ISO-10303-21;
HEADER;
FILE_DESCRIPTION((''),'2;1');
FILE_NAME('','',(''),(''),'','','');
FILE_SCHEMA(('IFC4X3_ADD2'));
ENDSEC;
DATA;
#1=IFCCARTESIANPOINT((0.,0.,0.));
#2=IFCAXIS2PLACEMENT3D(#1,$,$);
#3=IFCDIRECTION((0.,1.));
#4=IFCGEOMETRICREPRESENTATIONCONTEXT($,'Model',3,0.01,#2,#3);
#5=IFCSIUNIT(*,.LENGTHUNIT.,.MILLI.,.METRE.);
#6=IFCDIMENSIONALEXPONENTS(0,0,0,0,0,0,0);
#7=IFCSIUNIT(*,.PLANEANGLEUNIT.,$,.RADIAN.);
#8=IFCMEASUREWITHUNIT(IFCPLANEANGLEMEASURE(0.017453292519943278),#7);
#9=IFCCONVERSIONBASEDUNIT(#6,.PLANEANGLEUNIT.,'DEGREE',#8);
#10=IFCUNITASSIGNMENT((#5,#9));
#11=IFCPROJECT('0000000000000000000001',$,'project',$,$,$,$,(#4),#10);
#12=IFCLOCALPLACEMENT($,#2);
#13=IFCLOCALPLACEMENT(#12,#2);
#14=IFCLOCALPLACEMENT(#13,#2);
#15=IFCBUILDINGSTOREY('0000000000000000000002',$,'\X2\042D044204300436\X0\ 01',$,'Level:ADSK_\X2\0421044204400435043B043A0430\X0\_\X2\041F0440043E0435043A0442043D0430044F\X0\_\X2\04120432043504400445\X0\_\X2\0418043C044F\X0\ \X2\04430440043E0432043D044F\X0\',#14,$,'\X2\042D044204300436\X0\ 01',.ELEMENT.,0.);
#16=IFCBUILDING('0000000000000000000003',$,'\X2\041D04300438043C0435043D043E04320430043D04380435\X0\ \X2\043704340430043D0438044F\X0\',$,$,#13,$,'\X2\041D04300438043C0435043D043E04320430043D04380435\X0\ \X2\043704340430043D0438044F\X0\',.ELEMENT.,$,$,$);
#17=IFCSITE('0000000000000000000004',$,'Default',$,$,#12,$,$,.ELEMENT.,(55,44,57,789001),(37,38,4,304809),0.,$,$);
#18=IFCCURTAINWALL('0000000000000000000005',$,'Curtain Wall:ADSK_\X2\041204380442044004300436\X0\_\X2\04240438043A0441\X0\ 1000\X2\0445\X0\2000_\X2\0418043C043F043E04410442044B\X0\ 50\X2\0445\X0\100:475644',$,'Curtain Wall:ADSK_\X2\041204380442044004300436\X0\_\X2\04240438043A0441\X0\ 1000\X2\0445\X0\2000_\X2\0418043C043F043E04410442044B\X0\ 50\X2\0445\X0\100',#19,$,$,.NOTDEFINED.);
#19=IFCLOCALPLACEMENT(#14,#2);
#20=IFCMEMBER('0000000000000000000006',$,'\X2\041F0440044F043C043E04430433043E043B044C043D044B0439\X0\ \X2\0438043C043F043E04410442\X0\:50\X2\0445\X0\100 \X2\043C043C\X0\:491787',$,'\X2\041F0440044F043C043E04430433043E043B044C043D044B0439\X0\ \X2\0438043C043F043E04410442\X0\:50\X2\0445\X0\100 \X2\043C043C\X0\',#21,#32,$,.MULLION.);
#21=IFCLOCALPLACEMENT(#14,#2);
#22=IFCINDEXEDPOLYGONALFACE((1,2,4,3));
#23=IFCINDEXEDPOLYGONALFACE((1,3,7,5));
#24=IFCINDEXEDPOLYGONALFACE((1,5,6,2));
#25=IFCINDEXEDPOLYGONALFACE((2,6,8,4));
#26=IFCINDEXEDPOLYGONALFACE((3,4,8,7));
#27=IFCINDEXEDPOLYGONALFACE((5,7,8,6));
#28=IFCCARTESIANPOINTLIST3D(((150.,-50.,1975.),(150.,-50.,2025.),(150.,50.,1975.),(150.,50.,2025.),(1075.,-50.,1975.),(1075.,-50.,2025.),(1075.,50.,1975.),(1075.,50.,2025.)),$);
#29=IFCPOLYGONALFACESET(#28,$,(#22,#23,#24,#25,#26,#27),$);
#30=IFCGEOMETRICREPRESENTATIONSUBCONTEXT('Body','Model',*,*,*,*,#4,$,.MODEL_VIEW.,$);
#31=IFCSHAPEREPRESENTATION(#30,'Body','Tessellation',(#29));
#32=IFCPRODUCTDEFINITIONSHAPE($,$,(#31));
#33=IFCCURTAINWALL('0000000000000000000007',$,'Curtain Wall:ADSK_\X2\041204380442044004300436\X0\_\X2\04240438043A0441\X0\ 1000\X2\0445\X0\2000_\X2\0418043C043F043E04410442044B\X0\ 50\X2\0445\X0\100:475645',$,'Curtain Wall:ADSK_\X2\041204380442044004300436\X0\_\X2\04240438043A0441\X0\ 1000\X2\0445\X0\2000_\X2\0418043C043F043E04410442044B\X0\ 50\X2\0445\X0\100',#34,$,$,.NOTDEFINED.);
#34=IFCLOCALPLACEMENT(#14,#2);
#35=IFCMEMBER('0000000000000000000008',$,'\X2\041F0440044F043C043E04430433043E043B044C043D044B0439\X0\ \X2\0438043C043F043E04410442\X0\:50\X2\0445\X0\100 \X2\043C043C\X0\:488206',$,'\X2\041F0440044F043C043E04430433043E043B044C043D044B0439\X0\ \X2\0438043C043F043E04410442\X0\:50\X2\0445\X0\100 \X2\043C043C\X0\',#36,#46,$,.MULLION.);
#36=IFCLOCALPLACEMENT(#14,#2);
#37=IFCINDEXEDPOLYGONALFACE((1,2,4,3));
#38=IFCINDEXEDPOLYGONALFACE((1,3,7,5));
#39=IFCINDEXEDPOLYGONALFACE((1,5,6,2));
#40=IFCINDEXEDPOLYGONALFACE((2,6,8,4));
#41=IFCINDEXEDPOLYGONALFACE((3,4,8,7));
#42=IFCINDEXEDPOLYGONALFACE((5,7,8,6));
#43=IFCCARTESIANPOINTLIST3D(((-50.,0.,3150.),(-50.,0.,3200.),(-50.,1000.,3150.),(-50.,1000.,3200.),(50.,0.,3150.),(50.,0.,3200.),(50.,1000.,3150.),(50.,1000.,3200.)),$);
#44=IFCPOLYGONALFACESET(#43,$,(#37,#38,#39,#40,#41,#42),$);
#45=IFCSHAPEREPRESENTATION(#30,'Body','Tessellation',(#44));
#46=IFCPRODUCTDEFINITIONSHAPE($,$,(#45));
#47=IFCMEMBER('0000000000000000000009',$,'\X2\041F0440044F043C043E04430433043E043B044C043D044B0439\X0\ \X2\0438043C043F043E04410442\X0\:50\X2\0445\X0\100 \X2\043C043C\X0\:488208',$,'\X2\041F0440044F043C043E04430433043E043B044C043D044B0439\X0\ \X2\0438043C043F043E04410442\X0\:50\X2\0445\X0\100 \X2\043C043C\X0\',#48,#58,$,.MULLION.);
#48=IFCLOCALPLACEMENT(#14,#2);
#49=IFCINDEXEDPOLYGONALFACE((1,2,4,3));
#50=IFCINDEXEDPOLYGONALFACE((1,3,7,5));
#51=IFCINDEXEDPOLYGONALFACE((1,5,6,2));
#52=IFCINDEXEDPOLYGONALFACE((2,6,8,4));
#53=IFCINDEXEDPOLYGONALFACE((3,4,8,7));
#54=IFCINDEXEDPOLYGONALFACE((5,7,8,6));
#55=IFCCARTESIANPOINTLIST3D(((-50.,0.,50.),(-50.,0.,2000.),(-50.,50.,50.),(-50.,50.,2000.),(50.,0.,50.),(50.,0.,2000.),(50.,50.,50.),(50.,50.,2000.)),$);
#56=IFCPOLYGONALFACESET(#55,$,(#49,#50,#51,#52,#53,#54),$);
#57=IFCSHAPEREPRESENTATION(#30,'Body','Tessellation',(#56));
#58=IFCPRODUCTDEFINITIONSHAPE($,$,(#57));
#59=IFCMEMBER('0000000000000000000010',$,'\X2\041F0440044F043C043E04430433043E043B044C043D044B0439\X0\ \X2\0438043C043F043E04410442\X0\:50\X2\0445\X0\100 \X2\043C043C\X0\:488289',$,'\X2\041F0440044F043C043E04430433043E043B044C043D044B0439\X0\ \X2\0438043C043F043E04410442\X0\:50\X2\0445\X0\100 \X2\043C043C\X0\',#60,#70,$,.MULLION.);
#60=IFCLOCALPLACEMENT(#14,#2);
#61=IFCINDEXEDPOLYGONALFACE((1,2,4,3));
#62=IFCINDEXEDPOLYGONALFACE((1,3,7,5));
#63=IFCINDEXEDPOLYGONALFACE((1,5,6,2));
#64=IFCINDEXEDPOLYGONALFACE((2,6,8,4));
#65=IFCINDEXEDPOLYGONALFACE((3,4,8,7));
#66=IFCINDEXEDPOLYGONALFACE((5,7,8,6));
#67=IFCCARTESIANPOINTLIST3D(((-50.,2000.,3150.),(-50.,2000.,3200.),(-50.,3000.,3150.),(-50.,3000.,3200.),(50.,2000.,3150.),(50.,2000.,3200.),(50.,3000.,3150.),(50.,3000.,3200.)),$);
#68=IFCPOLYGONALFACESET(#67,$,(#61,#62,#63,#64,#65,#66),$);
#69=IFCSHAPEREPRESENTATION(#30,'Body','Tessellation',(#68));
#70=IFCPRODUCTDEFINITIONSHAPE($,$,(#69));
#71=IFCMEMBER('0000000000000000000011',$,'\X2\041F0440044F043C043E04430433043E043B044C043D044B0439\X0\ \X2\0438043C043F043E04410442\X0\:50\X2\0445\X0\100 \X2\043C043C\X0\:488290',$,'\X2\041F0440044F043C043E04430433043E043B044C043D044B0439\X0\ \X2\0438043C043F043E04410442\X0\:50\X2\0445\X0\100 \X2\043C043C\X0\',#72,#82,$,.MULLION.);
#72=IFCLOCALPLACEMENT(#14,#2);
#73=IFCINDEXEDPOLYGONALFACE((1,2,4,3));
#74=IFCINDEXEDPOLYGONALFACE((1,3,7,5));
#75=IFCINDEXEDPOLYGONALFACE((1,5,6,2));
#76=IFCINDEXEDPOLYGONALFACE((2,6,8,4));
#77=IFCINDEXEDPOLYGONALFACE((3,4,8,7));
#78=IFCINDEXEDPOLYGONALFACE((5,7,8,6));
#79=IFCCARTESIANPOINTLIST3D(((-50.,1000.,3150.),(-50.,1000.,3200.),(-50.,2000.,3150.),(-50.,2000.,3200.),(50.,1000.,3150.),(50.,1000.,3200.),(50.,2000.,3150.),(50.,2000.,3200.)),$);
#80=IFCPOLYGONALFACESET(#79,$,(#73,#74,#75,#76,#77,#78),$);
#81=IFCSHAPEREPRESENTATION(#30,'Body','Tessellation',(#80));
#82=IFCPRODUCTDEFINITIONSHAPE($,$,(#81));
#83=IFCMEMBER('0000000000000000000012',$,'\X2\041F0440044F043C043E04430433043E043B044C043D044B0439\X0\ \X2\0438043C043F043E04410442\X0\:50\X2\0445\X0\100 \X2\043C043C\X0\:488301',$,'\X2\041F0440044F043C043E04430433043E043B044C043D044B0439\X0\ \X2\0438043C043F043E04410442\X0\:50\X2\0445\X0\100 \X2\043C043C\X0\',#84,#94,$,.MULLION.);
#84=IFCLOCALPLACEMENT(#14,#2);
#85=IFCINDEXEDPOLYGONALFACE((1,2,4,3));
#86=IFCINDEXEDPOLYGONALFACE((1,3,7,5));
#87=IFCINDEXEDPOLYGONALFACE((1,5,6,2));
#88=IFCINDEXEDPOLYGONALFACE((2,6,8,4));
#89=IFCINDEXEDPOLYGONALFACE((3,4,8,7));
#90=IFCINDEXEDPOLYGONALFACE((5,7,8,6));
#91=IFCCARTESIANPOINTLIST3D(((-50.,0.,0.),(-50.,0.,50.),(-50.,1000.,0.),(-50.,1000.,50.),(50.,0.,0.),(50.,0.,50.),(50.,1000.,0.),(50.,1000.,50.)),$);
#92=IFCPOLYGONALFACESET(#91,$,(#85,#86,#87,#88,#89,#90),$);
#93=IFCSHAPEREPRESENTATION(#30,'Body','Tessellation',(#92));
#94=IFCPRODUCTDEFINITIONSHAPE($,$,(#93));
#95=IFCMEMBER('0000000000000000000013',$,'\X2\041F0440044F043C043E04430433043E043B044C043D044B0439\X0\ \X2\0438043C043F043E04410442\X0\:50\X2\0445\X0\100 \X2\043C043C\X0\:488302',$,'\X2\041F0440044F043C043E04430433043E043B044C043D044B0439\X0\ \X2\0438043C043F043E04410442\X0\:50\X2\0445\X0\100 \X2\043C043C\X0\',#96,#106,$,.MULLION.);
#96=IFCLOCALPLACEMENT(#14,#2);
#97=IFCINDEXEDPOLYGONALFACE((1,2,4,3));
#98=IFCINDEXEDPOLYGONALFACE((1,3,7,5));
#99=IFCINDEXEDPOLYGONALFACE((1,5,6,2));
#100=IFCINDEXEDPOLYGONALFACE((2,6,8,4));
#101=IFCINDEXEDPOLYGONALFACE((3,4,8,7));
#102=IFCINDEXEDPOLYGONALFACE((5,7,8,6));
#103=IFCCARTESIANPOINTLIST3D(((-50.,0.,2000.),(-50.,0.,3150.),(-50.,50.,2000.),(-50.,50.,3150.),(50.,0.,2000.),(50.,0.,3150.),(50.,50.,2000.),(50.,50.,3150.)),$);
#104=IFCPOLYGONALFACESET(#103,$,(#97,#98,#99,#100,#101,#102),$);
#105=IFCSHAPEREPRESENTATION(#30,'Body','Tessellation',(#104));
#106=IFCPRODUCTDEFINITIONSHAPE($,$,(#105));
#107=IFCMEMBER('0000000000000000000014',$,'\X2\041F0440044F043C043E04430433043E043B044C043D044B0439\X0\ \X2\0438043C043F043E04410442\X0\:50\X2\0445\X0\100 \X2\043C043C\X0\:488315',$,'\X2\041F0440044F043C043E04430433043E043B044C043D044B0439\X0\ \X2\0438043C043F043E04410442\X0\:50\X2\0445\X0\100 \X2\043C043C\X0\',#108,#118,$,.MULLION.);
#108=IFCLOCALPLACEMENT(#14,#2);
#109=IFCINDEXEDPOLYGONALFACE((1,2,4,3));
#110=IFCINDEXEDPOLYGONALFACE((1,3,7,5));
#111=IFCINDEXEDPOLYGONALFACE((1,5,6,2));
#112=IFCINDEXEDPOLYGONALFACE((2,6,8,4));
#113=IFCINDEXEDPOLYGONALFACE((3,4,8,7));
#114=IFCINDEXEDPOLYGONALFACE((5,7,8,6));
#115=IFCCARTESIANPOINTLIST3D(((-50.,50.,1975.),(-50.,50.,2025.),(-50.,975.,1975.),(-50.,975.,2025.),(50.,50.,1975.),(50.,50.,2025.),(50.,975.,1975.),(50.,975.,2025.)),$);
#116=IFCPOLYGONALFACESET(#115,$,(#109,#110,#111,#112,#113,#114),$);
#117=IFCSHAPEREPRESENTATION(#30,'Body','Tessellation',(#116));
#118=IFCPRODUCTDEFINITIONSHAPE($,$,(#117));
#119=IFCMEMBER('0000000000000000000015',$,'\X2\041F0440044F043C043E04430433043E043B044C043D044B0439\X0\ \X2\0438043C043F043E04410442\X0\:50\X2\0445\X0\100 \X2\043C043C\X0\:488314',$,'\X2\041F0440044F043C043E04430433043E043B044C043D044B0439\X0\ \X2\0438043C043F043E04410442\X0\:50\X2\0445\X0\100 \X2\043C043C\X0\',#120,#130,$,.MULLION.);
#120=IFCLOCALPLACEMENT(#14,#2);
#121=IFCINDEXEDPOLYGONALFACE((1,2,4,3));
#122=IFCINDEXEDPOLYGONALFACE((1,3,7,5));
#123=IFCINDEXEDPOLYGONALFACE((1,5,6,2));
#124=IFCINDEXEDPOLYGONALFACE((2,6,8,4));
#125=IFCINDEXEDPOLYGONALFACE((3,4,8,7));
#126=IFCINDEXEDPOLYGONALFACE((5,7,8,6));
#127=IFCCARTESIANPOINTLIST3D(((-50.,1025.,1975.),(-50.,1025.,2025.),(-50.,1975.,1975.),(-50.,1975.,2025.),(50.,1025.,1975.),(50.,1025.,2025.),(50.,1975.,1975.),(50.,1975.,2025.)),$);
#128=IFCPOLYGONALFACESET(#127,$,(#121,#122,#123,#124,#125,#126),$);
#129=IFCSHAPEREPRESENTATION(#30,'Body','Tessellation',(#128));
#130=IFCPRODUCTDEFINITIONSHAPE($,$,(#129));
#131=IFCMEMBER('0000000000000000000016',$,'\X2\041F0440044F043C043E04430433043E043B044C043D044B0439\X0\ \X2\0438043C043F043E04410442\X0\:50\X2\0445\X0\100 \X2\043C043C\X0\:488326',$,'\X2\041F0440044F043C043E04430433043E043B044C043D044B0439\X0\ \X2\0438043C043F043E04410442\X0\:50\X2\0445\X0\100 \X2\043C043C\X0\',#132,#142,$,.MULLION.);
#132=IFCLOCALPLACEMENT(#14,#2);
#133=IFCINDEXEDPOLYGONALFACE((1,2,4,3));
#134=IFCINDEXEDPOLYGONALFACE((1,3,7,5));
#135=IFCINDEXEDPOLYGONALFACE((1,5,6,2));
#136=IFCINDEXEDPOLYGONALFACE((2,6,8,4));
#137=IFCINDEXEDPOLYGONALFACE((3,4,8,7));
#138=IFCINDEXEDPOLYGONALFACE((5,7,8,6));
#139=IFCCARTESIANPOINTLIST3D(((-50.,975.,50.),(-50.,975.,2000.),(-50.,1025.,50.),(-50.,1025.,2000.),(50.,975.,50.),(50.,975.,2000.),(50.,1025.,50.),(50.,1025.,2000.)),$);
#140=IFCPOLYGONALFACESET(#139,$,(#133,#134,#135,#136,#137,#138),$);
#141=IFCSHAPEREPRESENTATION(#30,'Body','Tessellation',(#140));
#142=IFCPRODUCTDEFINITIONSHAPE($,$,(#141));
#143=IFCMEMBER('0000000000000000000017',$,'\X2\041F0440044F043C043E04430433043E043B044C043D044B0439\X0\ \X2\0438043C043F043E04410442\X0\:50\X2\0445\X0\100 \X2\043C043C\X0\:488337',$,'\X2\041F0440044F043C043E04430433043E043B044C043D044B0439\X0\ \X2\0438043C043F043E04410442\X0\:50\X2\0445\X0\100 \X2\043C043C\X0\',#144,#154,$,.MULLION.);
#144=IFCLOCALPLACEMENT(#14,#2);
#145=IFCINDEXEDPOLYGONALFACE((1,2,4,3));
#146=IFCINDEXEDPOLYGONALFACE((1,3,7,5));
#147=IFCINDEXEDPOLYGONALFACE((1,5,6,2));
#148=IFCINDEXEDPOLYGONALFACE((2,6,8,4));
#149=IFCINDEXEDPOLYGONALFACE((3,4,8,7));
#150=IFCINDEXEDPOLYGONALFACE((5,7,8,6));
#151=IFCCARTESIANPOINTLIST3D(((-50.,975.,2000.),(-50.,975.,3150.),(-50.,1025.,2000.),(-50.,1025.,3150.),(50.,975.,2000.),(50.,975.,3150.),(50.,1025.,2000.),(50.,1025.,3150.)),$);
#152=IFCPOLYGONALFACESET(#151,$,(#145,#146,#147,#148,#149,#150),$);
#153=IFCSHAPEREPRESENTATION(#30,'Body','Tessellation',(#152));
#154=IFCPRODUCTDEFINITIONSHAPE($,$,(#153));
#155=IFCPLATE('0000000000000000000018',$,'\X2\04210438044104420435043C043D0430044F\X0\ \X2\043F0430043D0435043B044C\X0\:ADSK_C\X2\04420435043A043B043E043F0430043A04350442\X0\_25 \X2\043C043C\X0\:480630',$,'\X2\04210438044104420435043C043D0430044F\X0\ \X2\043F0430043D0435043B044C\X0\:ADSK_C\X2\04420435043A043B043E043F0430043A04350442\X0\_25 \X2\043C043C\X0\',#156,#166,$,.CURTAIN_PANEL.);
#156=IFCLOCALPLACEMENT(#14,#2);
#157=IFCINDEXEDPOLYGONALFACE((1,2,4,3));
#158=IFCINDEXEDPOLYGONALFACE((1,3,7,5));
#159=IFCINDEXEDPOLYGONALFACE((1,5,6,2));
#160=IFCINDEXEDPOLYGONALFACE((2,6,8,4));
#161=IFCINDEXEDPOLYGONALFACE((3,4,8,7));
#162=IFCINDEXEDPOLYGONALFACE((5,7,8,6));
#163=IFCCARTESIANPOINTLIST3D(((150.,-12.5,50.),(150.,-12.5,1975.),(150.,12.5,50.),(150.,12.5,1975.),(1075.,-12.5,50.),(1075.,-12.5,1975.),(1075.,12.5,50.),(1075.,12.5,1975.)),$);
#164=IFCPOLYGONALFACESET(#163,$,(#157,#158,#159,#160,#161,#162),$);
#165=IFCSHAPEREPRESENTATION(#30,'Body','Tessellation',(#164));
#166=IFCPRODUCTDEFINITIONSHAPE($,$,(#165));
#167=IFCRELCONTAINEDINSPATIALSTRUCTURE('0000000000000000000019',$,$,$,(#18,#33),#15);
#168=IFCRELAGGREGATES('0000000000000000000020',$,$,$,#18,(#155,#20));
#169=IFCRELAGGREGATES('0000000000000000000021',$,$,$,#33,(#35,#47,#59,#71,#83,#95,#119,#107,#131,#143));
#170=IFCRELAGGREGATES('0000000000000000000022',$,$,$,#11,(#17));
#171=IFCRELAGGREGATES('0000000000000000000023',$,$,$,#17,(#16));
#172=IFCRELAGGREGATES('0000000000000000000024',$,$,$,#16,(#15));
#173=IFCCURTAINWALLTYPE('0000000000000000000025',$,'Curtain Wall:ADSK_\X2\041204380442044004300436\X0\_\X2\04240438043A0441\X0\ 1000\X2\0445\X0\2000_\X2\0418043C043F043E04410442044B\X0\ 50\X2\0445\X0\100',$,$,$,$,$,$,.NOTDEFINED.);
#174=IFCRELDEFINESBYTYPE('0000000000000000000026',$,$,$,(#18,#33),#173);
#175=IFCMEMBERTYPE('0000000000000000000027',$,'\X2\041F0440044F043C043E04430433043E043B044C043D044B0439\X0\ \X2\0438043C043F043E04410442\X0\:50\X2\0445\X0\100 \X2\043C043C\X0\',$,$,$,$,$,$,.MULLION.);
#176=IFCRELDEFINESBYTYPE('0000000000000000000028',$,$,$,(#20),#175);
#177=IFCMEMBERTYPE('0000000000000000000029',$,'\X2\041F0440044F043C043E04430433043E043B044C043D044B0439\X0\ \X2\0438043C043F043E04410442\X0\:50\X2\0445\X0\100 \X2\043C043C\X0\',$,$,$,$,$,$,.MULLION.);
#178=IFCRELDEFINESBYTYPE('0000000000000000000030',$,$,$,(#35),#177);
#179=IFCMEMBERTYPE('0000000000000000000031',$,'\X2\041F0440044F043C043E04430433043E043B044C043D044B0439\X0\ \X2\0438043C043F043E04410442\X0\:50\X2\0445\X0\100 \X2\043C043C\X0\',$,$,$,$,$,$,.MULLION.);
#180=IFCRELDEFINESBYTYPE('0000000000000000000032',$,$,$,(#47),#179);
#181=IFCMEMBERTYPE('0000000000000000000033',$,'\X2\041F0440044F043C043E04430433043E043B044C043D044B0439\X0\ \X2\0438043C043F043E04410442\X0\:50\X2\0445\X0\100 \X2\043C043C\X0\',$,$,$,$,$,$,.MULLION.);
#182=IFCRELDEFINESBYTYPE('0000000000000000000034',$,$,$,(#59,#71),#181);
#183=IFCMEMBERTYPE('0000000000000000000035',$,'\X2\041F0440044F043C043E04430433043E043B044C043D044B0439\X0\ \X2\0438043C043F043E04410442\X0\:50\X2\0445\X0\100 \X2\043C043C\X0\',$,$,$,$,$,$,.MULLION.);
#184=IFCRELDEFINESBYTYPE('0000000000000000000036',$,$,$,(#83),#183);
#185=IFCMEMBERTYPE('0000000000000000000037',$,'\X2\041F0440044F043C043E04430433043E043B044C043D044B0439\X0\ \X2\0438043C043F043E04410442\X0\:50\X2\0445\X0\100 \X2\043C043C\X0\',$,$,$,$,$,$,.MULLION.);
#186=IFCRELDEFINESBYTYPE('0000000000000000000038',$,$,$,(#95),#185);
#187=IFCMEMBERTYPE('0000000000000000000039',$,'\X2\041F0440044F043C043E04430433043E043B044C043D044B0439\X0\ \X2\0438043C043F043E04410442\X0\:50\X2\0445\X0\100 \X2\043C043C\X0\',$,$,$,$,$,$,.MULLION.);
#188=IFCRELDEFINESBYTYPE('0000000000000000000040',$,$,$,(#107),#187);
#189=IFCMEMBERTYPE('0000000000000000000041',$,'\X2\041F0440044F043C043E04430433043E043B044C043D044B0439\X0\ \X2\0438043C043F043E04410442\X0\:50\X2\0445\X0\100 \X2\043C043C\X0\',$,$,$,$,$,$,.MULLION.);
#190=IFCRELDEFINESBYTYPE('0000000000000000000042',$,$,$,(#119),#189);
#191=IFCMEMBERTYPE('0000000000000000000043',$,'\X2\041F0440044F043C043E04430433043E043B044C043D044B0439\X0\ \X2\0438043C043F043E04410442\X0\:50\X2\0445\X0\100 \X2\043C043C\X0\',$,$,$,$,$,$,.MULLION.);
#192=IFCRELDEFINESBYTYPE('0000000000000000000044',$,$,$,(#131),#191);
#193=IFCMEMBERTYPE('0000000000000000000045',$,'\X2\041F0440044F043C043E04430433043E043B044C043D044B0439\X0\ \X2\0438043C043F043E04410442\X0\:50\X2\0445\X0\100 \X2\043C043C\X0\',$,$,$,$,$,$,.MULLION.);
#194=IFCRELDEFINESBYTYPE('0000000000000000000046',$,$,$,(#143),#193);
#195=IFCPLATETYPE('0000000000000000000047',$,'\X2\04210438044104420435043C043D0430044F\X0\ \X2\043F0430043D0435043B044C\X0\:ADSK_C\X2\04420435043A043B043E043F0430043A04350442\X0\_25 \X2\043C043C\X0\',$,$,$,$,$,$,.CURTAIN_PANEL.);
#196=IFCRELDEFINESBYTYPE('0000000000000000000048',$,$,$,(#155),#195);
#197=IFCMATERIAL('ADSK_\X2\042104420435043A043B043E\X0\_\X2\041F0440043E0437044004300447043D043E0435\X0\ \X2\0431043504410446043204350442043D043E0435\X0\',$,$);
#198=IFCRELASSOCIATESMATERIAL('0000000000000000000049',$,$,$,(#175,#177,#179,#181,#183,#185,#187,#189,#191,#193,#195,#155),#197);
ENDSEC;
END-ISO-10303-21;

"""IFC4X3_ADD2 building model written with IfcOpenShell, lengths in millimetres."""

from ifc_helpers import new_model, entity, si_unit, converted_unit, direction, frame, frame_2d, origin, origin_2d_with_axis, place, context, subcontext, project, spatial, rectangle, extrude, source, transform, mapped, material, material_profile, profile_set, type_object, type_shapes, element, aggregate, save


model = new_model("IFC4X3_ADD2")

# Units and contexts
model_context = context("Model", 3, precision=0.01, world=origin(), true_north=direction((0.0, 1.0)))
body_context = subcontext(model_context, "Body", "Model", "MODEL_VIEW")
ifc_project = project(units=[si_unit("LENGTHUNIT", "METRE", prefix="MILLI"), converted_unit("PLANEANGLEUNIT", "DEGREE", entity("IfcPlaneAngleMeasure", 0.017453292519943278), si_unit("PLANEANGLEUNIT", "RADIAN"), dimensions=[0, 0, 0, 0, 0, 0, 0])], contexts=[model_context])

# Site, building, storey
site_placement = place(None, origin())
site = spatial("IfcSite", under=ifc_project, at=site_placement, Name="Default", CompositionType="ELEMENT", RefLatitude=(55, 44, 57, 789001), RefLongitude=(37, 38, 4, 304809), RefElevation=0.0)
building_placement = place(site_placement, origin())
building = spatial("IfcBuilding", under=site, at=building_placement, Name="Наименование здания", LongName="Наименование здания", CompositionType="ELEMENT")
storey_placement = place(building_placement, origin())
storey = spatial("IfcBuildingStorey", under=building, at=storey_placement, Name="Этаж 01", ObjectType="Level:ADSK_Стрелка_Проектная_Вверх_Имя уровня", LongName="Этаж 01", CompositionType="ELEMENT", Elevation=0.0)

# Curtain walls, members
curtain_wall_type = type_object("IfcCurtainWallType", Name="Curtain Wall:ADSK_Витраж_Фикс 1000х2000_Импосты 50х100", PredefinedType="NOTDEFINED")
curtain_wall_1_placement = place(storey_placement, origin())
curtain_wall_1 = element("IfcCurtainWall", 1, at=curtain_wall_1_placement, inside=storey, type_object=curtain_wall_type, Name="Curtain Wall:ADSK_Витраж_Фикс 1000х2000_Импосты 50х100:475644", ObjectType="Curtain Wall:ADSK_Витраж_Фикс 1000х2000_Импосты 50х100", PredefinedType="NOTDEFINED")
ifc_material_1 = material(Name="ADSK_Стекло_Прозрачное бесцветное")
ifc_material_profile = material_profile(ifc_material_1, rectangle(XDim=50.0, YDim=100.0, at=frame_2d((0.0, 0.0), x_axis=(1.0, 0.0))), Name="50х100 мм")
ifc_profile_set = profile_set([ifc_material_profile], Name="50х100 мм")
member_type_1 = type_object("IfcMemberType", Name="Прямоугольный импост:50х100 мм", PredefinedType="MULLION", material=ifc_profile_set)
shared_shape_1 = source(origin(), body_context, "Body", "SweptSolid", [
    extrude(rectangle(XDim=50.0, YDim=100.0, at=frame_2d((0.0, 0.0), x_axis=(1.0, 0.0))), frame((0.0, 0.0, -925.0), z_axis=(0.0, 0.0, 1.0), x_axis=(-1.0, 0.0, 0.0)), (0.0, 0.0, 1.0), 925.0),
])
type_shapes(member_type_1, [shared_shape_1])
member_1_placement = place(curtain_wall_1_placement, frame((1075.0, 0.0, 2000.0), z_axis=(1.0, 0.0, 0.0), x_axis=(0.0, 0.0, 1.0)))
member_1 = element("IfcMember", 2, at=member_1_placement, type_object=member_type_1, Name="Прямоугольный импост:50х100 мм:491787", ObjectType="Прямоугольный импост:50х100 мм", PredefinedType="MULLION", context=body_context, shape_type="MappedRepresentation", body=[
    mapped(shared_shape_1, transform((0.0, 0.0, 0.0), scale=1.0)),
])
curtain_wall_2_placement = place(storey_placement, origin())
curtain_wall_2 = element("IfcCurtainWall", 3, at=curtain_wall_2_placement, inside=storey, type_object=curtain_wall_type, Name="Curtain Wall:ADSK_Витраж_Фикс 1000х2000_Импосты 50х100:475645", ObjectType="Curtain Wall:ADSK_Витраж_Фикс 1000х2000_Импосты 50х100", PredefinedType="NOTDEFINED")
member_type_2 = type_object("IfcMemberType", Name="Прямоугольный импост:50х100 мм", PredefinedType="MULLION", material=ifc_profile_set)
shared_shape_2 = source(origin(), body_context, "Body", "SweptSolid", [
    extrude(rectangle(XDim=50.0, YDim=100.0, at=frame_2d((0.0, 0.0), x_axis=(1.0, 0.0))), frame((-25.0, 0.0, -1000.0), z_axis=(0.0, 0.0, 1.0), x_axis=(-1.0, 0.0, 0.0)), (0.0, 0.0, 1.0), 1000.0),
])
type_shapes(member_type_2, [shared_shape_2])
member_2_placement = place(curtain_wall_2_placement, frame((0.0, 0.0, 3200.0), z_axis=(0.0, -1.0, 0.0), x_axis=(0.0, 0.0, 1.0)))
member_2 = element("IfcMember", 4, at=member_2_placement, type_object=member_type_2, Name="Прямоугольный импост:50х100 мм:488206", ObjectType="Прямоугольный импост:50х100 мм", PredefinedType="MULLION", context=body_context, shape_type="MappedRepresentation", body=[
    mapped(shared_shape_2, transform((0.0, 0.0, 0.0), scale=1.0)),
])
member_type_3 = type_object("IfcMemberType", Name="Прямоугольный импост:50х100 мм", PredefinedType="MULLION", material=ifc_profile_set)
shared_shape_3 = source(origin(), body_context, "Body", "SweptSolid", [
    extrude(rectangle(XDim=50.0, YDim=100.0, at=frame_2d((0.0, 0.0), x_axis=(1.0, 0.0))), frame((-25.0, 0.0, -1950.0), z_axis=(0.0, 0.0, 1.0), x_axis=(-1.0, 0.0, 0.0)), (0.0, 0.0, 1.0), 1950.0),
])
type_shapes(member_type_3, [shared_shape_3])
member_3_placement = place(curtain_wall_2_placement, frame((0.0, 0.0, 50.0), z_axis=(0.0, 0.0, -1.0), x_axis=(0.0, -1.0, 0.0)))
member_3 = element("IfcMember", 5, at=member_3_placement, type_object=member_type_3, Name="Прямоугольный импост:50х100 мм:488208", ObjectType="Прямоугольный импост:50х100 мм", PredefinedType="MULLION", context=body_context, shape_type="MappedRepresentation", body=[
    mapped(shared_shape_3, transform((0.0, 0.0, 0.0), scale=1.0)),
])
member_type_4 = type_object("IfcMemberType", Name="Прямоугольный импост:50х100 мм", PredefinedType="MULLION", material=ifc_profile_set)
shared_shape_4 = source(origin(), body_context, "Body", "SweptSolid", [
    extrude(rectangle(XDim=50.0, YDim=100.0, at=frame_2d((0.0, 0.0), x_axis=(1.0, 0.0))), frame((-25.0, 0.0, -1000.0), z_axis=(0.0, 0.0, 1.0), x_axis=(-1.0, 0.0, 0.0)), (0.0, 0.0, 1.0), 1000.0),
])
type_shapes(member_type_4, [shared_shape_4])
member_4_placement = place(curtain_wall_2_placement, frame((0.0, 2000.0, 3200.0), z_axis=(0.0, -1.0, 0.0), x_axis=(0.0, 0.0, 1.0)))
member_4 = element("IfcMember", 6, at=member_4_placement, type_object=member_type_4, Name="Прямоугольный импост:50х100 мм:488289", ObjectType="Прямоугольный импост:50х100 мм", PredefinedType="MULLION", context=body_context, shape_type="MappedRepresentation", body=[
    mapped(shared_shape_4, transform((0.0, 0.0, 0.0), scale=1.0)),
])
member_5_placement = place(curtain_wall_2_placement, frame((0.0, 1000.0, 3200.0), z_axis=(0.0, -1.0, 0.0), x_axis=(0.0, 0.0, 1.0)))
member_5 = element("IfcMember", 7, at=member_5_placement, type_object=member_type_4, Name="Прямоугольный импост:50х100 мм:488290", ObjectType="Прямоугольный импост:50х100 мм", PredefinedType="MULLION", context=body_context, shape_type="MappedRepresentation", body=[
    mapped(shared_shape_4, transform((0.0, 0.0, 0.0), scale=1.0)),
])
member_type_5 = type_object("IfcMemberType", Name="Прямоугольный импост:50х100 мм", PredefinedType="MULLION", material=ifc_profile_set)
shared_shape_5 = source(origin(), body_context, "Body", "SweptSolid", [
    extrude(rectangle(XDim=50.0, YDim=100.0, at=frame_2d((0.0, 0.0), x_axis=(1.0, 0.0))), frame((-25.0, 0.0, -1000.0), z_axis=(0.0, 0.0, 1.0), x_axis=(-1.0, 0.0, 0.0)), (0.0, 0.0, 1.0), 1000.0),
])
type_shapes(member_type_5, [shared_shape_5])
member_6_placement = place(curtain_wall_2_placement, frame((0.0, 1000.0, 0.0), z_axis=(0.0, 1.0, 0.0), x_axis=(0.0, 0.0, -1.0)))
member_6 = element("IfcMember", 8, at=member_6_placement, type_object=member_type_5, Name="Прямоугольный импост:50х100 мм:488301", ObjectType="Прямоугольный импост:50х100 мм", PredefinedType="MULLION", context=body_context, shape_type="MappedRepresentation", body=[
    mapped(shared_shape_5, transform((0.0, 0.0, 0.0), scale=1.0)),
])
member_type_6 = type_object("IfcMemberType", Name="Прямоугольный импост:50х100 мм", PredefinedType="MULLION", material=ifc_profile_set)
shared_shape_6 = source(origin(), body_context, "Body", "SweptSolid", [
    extrude(rectangle(XDim=50.0, YDim=100.0, at=frame_2d((0.0, 0.0), x_axis=(1.0, 0.0))), frame((-25.0, 0.0, -1150.0), z_axis=(0.0, 0.0, 1.0), x_axis=(-1.0, 0.0, 0.0)), (0.0, 0.0, 1.0), 1150.0),
])
type_shapes(member_type_6, [shared_shape_6])
member_7_placement = place(curtain_wall_2_placement, frame((0.0, 0.0, 2000.0), z_axis=(0.0, 0.0, -1.0), x_axis=(0.0, -1.0, 0.0)))
member_7 = element("IfcMember", 9, at=member_7_placement, type_object=member_type_6, Name="Прямоугольный импост:50х100 мм:488302", ObjectType="Прямоугольный импост:50х100 мм", PredefinedType="MULLION", context=body_context, shape_type="MappedRepresentation", body=[
    mapped(shared_shape_6, transform((0.0, 0.0, 0.0), scale=1.0)),
])
member_type_7 = type_object("IfcMemberType", Name="Прямоугольный импост:50х100 мм", PredefinedType="MULLION", material=ifc_profile_set)
shared_shape_7 = source(origin(), body_context, "Body", "SweptSolid", [
    extrude(rectangle(XDim=50.0, YDim=100.0, at=frame_2d((0.0, 0.0), x_axis=(1.0, 0.0))), frame((0.0, 0.0, -925.0), z_axis=(0.0, 0.0, 1.0), x_axis=(-1.0, 0.0, 0.0)), (0.0, 0.0, 1.0), 925.0),
])
type_shapes(member_type_7, [shared_shape_7])
member_8_placement = place(curtain_wall_2_placement, frame((0.0, 50.0, 2000.0), z_axis=(0.0, -1.0, 0.0), x_axis=(0.0, 0.0, 1.0)))
member_8 = element("IfcMember", 10, at=member_8_placement, type_object=member_type_7, Name="Прямоугольный импост:50х100 мм:488315", ObjectType="Прямоугольный импост:50х100 мм", PredefinedType="MULLION", context=body_context, shape_type="MappedRepresentation", body=[
    mapped(shared_shape_7, transform((0.0, 0.0, 0.0), scale=1.0)),
])
member_type_8 = type_object("IfcMemberType", Name="Прямоугольный импост:50х100 мм", PredefinedType="MULLION", material=ifc_profile_set)
shared_shape_8 = source(origin(), body_context, "Body", "SweptSolid", [
    extrude(rectangle(XDim=50.0, YDim=100.0, at=frame_2d((0.0, 0.0), x_axis=(1.0, 0.0))), frame((0.0, 0.0, -950.0), z_axis=(0.0, 0.0, 1.0), x_axis=(-1.0, 0.0, 0.0)), (0.0, 0.0, 1.0), 950.0),
])
type_shapes(member_type_8, [shared_shape_8])
member_9_placement = place(curtain_wall_2_placement, frame((0.0, 1025.0, 2000.0), z_axis=(0.0, -1.0, 0.0), x_axis=(0.0, 0.0, 1.0)))
member_9 = element("IfcMember", 11, at=member_9_placement, type_object=member_type_8, Name="Прямоугольный импост:50х100 мм:488314", ObjectType="Прямоугольный импост:50х100 мм", PredefinedType="MULLION", context=body_context, shape_type="MappedRepresentation", body=[
    mapped(shared_shape_8, transform((0.0, 0.0, 0.0), scale=1.0)),
])
member_type_9 = type_object("IfcMemberType", Name="Прямоугольный импост:50х100 мм", PredefinedType="MULLION", material=ifc_profile_set)
shared_shape_9 = source(origin(), body_context, "Body", "SweptSolid", [
    extrude(rectangle(XDim=50.0, YDim=100.0, at=frame_2d((0.0, 0.0), x_axis=(1.0, 0.0))), frame((0.0, 0.0, -1950.0), z_axis=(0.0, 0.0, 1.0), x_axis=(-1.0, 0.0, 0.0)), (0.0, 0.0, 1.0), 1950.0),
])
type_shapes(member_type_9, [shared_shape_9])
member_10_placement = place(curtain_wall_2_placement, frame((0.0, 1000.0, 50.0), z_axis=(0.0, 0.0, -1.0), x_axis=(0.0, -1.0, 0.0)))
member_10 = element("IfcMember", 12, at=member_10_placement, type_object=member_type_9, Name="Прямоугольный импост:50х100 мм:488326", ObjectType="Прямоугольный импост:50х100 мм", PredefinedType="MULLION", context=body_context, shape_type="MappedRepresentation", body=[
    mapped(shared_shape_9, transform((0.0, 0.0, 0.0), scale=1.0)),
])
member_type_10 = type_object("IfcMemberType", Name="Прямоугольный импост:50х100 мм", PredefinedType="MULLION", material=ifc_profile_set)
shared_shape_10 = source(origin(), body_context, "Body", "SweptSolid", [
    extrude(rectangle(XDim=50.0, YDim=100.0, at=frame_2d((0.0, 0.0), x_axis=(1.0, 0.0))), frame((0.0, 0.0, -1150.0), z_axis=(0.0, 0.0, 1.0), x_axis=(-1.0, 0.0, 0.0)), (0.0, 0.0, 1.0), 1150.0),
])
type_shapes(member_type_10, [shared_shape_10])
member_11_placement = place(curtain_wall_2_placement, frame((0.0, 1000.0, 2000.0), z_axis=(0.0, 0.0, -1.0), x_axis=(0.0, -1.0, 0.0)))
member_11 = element("IfcMember", 13, at=member_11_placement, type_object=member_type_10, Name="Прямоугольный импост:50х100 мм:488337", ObjectType="Прямоугольный импост:50х100 мм", PredefinedType="MULLION", context=body_context, shape_type="MappedRepresentation", body=[
    mapped(shared_shape_10, transform((0.0, 0.0, 0.0), scale=1.0)),
])

# Plate
plate_type_1 = type_object("IfcPlateType", Name="Системная панель:ADSK_Cтеклопакет_25 мм", PredefinedType="CURTAIN_PANEL", material=ifc_material_1)
shared_shape_11 = source(origin(), body_context, "Body", "SweptSolid", [
    extrude(rectangle(XDim=25.0, YDim=925.0, at=origin_2d_with_axis()), frame((0.0, 0.0, 0.0), z_axis=(0.0, 0.0, 1.0), x_axis=(0.0, 1.0, 0.0)), (0.0, 0.0, 1.0), 1925.0),
])
type_shapes(plate_type_1, [shared_shape_11])
plate_1_placement = place(curtain_wall_1_placement, frame((612.5, 0.0, 50.0)))
plate_1 = element("IfcPlate", 14, at=plate_1_placement, type_object=plate_type_1, material=ifc_material_1, Name="Системная панель:ADSK_Cтеклопакет_25 мм:480630", ObjectType="Системная панель:ADSK_Cтеклопакет_25 мм", PredefinedType="CURTAIN_PANEL", context=body_context, shape_type="MappedRepresentation", body=[
    mapped(shared_shape_11, transform((0.0, 0.0, 0.0), scale=1.0)),
])
aggregate(curtain_wall_1, [plate_1, member_1])
aggregate(curtain_wall_2, [member_2, member_3, member_4, member_5, member_6, member_7, member_9, member_8, member_10, member_11])

save(model, "model.ifc")
